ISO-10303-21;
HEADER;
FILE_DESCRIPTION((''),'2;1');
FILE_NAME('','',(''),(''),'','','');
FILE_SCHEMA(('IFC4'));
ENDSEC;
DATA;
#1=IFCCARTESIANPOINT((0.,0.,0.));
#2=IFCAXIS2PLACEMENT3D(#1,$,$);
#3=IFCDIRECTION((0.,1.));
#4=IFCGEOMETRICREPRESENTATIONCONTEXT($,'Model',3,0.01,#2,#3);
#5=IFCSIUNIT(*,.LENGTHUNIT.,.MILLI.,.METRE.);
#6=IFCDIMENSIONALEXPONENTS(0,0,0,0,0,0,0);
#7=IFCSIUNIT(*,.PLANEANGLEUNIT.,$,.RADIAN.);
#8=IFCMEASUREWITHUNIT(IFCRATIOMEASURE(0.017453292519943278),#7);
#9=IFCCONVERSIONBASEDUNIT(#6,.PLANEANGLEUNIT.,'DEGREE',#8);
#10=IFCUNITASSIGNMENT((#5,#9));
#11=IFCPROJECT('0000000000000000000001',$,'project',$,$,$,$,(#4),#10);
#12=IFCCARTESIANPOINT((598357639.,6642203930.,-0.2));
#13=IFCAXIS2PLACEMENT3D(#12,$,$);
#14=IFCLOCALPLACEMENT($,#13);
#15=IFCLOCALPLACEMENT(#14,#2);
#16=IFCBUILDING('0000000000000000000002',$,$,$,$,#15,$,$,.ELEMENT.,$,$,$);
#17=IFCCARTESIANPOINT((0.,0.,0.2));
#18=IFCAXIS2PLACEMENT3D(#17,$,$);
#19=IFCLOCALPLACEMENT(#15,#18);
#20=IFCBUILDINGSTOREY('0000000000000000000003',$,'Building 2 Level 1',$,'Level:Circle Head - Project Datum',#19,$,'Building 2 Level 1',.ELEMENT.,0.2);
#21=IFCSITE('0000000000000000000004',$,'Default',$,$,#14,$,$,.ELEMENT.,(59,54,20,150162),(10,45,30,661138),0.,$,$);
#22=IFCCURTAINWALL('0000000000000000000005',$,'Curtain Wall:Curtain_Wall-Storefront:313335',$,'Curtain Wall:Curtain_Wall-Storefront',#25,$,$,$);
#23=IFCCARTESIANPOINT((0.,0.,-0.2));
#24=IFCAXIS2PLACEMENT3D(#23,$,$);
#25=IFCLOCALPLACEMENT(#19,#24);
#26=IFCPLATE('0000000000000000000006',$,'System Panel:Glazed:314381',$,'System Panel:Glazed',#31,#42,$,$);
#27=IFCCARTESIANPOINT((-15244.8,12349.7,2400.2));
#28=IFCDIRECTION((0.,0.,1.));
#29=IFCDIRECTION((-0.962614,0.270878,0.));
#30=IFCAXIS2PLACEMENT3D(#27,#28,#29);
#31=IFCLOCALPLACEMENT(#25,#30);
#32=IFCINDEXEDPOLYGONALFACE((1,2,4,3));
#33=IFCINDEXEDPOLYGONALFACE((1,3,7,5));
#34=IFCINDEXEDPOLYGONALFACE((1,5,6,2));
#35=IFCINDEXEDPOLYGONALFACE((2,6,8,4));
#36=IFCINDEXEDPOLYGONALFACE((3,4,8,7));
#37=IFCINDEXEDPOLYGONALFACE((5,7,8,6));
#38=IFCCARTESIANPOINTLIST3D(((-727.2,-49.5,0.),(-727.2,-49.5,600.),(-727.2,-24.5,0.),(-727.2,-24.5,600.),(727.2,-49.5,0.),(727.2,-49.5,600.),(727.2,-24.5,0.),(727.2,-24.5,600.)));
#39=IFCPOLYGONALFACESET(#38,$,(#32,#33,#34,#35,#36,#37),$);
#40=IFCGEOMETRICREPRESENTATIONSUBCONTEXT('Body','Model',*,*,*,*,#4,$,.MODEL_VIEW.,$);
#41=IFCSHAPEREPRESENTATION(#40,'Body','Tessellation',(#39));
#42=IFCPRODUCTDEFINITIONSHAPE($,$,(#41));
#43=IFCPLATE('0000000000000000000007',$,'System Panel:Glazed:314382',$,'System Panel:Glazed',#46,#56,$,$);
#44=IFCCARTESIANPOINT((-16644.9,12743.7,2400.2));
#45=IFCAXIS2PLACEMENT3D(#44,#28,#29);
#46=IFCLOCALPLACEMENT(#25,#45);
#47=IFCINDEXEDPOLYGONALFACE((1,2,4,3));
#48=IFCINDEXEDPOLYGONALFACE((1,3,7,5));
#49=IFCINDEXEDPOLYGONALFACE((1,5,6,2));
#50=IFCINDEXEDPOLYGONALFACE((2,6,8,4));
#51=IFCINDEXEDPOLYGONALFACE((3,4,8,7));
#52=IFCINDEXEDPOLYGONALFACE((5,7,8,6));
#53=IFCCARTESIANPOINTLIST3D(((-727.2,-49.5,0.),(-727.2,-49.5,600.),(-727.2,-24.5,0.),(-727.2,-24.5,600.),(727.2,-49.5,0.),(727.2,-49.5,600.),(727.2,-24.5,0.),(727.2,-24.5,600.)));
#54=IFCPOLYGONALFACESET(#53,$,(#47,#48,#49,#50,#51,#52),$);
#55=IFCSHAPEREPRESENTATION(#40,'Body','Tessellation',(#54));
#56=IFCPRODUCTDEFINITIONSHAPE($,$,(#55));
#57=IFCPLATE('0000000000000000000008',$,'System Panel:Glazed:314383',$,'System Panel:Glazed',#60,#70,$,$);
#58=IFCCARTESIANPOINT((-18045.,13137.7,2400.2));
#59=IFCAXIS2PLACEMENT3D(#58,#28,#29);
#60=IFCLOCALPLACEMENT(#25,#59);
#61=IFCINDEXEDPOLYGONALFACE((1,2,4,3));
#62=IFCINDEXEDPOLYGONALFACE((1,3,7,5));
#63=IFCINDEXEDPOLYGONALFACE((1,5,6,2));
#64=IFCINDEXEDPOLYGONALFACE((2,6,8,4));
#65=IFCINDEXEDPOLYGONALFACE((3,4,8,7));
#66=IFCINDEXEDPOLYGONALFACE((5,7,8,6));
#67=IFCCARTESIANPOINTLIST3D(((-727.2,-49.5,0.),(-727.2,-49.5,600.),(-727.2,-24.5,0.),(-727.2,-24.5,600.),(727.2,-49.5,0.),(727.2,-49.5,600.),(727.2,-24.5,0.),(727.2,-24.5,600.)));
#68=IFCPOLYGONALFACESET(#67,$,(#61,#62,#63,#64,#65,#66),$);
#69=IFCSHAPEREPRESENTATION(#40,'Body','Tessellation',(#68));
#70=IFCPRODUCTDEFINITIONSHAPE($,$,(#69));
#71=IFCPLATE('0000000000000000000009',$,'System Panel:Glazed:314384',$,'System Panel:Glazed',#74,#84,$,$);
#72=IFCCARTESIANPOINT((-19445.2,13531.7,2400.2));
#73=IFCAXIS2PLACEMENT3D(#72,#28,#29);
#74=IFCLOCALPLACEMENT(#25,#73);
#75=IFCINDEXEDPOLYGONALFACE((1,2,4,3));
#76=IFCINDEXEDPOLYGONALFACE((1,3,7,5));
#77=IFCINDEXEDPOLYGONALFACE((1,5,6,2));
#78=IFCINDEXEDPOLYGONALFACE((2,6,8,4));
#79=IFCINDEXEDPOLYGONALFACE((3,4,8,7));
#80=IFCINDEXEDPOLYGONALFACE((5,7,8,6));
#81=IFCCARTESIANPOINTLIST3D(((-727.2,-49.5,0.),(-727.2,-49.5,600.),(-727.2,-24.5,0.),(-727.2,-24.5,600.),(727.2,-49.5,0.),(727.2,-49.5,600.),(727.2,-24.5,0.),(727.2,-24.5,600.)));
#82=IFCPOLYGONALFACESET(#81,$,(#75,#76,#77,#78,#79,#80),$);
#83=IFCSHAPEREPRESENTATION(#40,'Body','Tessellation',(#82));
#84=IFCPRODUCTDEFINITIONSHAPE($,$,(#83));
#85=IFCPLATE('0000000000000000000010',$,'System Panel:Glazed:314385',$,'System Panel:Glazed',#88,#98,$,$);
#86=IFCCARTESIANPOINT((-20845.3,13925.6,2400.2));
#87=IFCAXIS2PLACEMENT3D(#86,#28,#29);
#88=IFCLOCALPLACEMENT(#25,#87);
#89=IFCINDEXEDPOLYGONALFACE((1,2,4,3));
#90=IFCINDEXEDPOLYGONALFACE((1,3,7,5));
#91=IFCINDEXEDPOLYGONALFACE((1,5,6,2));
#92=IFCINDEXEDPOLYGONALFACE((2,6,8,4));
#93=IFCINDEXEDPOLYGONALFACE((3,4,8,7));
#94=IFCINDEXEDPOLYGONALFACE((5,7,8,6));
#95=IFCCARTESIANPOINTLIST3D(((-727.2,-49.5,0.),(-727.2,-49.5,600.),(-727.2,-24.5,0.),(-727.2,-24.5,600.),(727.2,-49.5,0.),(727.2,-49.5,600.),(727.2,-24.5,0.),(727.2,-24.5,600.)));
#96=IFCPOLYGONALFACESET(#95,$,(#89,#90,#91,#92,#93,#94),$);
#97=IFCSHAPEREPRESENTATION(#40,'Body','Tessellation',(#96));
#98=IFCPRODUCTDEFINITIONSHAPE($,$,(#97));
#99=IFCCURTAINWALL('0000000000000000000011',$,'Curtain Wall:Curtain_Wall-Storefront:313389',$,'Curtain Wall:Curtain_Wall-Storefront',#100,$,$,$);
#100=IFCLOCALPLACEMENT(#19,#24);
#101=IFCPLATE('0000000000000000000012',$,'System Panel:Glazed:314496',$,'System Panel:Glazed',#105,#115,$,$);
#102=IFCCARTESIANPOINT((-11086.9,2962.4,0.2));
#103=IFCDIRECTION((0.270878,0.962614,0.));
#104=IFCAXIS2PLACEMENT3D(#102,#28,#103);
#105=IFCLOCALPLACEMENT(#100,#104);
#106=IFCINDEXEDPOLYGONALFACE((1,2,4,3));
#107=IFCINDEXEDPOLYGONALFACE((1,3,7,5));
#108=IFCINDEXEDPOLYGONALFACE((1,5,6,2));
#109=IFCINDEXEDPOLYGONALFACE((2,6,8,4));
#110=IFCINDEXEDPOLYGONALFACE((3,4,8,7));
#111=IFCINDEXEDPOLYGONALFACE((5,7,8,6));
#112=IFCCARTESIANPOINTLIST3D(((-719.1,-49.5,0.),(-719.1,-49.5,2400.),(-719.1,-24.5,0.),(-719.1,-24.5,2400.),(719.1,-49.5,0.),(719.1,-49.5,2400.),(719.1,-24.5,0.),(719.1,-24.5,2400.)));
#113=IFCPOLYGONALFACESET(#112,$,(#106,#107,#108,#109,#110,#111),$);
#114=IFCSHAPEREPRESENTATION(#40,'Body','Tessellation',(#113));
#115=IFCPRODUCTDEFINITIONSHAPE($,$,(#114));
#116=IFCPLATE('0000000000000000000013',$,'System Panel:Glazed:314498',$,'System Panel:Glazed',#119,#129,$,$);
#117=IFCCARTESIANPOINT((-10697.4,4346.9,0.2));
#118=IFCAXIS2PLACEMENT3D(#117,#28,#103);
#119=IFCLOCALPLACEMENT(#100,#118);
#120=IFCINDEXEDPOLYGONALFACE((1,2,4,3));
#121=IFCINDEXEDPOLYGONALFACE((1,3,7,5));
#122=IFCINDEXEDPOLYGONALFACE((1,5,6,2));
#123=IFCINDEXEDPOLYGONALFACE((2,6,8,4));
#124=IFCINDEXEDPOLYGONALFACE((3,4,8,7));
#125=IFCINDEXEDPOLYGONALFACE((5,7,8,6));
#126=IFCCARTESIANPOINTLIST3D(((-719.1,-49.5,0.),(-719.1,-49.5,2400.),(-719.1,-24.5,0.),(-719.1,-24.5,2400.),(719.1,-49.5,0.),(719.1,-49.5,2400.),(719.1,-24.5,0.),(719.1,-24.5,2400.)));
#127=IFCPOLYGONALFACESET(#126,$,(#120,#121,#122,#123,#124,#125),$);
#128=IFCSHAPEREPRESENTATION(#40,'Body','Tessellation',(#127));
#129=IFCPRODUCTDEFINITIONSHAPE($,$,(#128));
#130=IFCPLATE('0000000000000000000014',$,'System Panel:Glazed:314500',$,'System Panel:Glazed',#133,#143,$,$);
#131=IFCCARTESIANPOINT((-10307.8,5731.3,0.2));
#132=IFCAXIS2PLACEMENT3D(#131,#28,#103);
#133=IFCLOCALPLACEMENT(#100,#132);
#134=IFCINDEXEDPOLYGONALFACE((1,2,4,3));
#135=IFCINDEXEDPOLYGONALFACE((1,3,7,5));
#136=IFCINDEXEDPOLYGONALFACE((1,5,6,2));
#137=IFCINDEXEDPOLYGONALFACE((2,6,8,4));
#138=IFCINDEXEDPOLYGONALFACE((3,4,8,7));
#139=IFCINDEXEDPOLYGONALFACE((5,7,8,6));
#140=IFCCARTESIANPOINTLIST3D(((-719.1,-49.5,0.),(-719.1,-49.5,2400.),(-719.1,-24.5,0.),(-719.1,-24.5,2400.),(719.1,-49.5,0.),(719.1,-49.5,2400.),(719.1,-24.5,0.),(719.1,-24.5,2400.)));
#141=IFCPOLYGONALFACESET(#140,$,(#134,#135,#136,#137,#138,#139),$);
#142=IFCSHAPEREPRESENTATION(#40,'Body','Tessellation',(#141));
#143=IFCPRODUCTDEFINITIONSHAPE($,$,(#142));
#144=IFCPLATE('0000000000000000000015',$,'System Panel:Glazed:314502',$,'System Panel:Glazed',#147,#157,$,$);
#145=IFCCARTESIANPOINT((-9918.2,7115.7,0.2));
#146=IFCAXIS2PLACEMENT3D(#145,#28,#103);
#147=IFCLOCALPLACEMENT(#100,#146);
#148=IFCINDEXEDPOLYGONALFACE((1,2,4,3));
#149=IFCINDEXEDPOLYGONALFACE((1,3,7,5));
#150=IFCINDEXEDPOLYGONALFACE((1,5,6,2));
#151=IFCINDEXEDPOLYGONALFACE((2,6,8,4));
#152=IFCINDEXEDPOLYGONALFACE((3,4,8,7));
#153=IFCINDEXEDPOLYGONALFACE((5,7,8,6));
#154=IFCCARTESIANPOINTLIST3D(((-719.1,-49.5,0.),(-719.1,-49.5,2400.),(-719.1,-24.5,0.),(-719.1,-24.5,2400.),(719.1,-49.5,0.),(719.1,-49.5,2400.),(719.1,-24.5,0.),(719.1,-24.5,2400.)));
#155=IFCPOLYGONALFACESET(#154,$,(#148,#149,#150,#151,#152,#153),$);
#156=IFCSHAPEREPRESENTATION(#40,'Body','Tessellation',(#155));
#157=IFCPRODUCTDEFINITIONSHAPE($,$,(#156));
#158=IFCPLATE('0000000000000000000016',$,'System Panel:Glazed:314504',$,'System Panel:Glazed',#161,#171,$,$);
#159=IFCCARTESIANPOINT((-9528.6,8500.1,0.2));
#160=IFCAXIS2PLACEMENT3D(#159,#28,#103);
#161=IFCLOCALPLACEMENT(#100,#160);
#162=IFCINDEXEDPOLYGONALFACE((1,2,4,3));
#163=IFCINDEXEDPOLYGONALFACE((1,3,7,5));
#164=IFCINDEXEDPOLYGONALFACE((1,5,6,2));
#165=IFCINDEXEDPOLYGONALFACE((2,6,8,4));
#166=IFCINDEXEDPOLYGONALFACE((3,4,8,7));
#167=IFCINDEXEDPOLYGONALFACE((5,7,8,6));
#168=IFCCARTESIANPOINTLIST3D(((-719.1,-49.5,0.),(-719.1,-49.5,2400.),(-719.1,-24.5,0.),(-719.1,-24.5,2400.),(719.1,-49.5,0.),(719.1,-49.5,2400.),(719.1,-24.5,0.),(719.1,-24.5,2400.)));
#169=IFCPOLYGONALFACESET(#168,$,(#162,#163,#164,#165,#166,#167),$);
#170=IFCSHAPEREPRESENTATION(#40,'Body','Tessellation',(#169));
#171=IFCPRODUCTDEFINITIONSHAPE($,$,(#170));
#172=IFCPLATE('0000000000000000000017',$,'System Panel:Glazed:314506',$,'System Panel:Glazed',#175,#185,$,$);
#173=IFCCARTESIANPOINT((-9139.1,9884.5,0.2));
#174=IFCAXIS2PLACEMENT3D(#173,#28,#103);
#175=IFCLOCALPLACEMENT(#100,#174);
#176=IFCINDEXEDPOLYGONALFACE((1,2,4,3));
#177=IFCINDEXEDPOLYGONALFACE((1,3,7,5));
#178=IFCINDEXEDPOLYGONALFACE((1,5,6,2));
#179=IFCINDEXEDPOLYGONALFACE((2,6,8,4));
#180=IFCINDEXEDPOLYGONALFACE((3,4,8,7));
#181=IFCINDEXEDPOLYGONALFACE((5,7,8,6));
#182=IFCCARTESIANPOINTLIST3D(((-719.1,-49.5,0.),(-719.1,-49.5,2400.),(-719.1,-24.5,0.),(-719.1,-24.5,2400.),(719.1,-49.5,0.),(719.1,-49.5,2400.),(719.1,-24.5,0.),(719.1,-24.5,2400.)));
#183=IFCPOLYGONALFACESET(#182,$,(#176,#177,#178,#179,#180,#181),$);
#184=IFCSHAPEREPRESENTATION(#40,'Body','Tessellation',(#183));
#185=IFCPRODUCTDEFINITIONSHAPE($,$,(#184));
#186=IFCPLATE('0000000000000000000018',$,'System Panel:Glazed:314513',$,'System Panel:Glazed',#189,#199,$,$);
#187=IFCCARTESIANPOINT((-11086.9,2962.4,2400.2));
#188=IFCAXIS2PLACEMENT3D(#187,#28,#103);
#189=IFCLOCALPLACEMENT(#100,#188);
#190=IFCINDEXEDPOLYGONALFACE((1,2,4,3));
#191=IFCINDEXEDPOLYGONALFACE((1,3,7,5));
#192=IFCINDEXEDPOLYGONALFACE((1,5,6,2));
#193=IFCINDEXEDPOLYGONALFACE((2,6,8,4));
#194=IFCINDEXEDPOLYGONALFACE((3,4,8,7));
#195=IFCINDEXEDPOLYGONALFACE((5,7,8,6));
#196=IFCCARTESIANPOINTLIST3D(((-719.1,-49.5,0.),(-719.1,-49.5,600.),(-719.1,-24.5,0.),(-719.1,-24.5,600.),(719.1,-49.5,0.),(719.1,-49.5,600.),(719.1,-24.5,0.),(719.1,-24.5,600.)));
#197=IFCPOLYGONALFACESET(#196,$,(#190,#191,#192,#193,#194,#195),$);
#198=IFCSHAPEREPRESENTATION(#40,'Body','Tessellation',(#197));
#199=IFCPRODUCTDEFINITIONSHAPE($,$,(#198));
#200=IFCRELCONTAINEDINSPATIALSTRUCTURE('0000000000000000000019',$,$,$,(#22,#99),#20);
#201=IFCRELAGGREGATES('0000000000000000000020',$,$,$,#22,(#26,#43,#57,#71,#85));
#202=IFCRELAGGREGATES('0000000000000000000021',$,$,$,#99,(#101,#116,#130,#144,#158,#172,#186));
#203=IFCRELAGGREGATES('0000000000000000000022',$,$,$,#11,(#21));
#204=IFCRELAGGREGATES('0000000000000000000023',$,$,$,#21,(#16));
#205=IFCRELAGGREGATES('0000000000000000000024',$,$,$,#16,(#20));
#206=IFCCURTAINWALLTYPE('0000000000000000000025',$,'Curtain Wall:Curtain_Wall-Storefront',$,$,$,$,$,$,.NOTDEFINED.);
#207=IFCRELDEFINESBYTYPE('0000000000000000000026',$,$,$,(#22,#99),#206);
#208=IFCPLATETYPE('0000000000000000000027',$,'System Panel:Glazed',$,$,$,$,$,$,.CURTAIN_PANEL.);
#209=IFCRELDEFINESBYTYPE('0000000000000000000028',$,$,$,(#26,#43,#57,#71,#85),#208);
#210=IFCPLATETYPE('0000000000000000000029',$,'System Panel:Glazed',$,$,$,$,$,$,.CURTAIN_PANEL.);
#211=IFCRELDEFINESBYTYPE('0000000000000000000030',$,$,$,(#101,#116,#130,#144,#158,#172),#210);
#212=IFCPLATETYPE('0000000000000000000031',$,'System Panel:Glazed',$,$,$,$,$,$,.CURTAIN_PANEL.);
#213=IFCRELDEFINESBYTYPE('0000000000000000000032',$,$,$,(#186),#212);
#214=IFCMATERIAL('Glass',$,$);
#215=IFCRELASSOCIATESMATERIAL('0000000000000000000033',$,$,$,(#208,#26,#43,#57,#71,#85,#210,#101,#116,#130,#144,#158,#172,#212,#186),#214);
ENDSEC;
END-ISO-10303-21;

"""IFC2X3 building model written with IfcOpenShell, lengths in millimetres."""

from ifc_helpers import new_model, entity, si_unit, converted_unit, direction, frame, frame_2d, origin, place, context, subcontext, project, spatial, rectangle, extrude, source, transform, mapped, material, type_object, type_shapes, element, aggregate, save


model = new_model("IFC2X3")

# Units and contexts
model_context = context("Model", 3, precision=0.01, world=origin(), true_north=direction((0.0, 1.0)))
body_context = subcontext(model_context, "Body", "Model", "MODEL_VIEW")
ifc_project = project(units=[si_unit("LENGTHUNIT", "METRE", prefix="MILLI"), converted_unit("PLANEANGLEUNIT", "DEGREE", entity("IfcRatioMeasure", 0.017453292519943278), si_unit("PLANEANGLEUNIT", "RADIAN"), dimensions=[0, 0, 0, 0, 0, 0, 0])], contexts=[model_context])

# Site, building, storey
site_placement = place(None, frame((598357639.0, 6642203930.0, -0.2)))
site = spatial("IfcSite", under=ifc_project, at=site_placement, Name="Default", CompositionType="ELEMENT", RefLatitude=(59, 54, 20, 150162), RefLongitude=(10, 45, 30, 661138), RefElevation=0.0)
building_placement = place(site_placement, origin())
building = spatial("IfcBuilding", under=site, at=building_placement, CompositionType="ELEMENT")
storey_placement = place(building_placement, frame((0.0, 0.0, 0.2)))
storey = spatial("IfcBuildingStorey", under=building, at=storey_placement, Name="Building 2 Level 1", ObjectType="Level:Circle Head - Project Datum", LongName="Building 2 Level 1", CompositionType="ELEMENT", Elevation=0.2)

# Curtain walls, plates
curtain_wall_type = type_object("IfcCurtainWallType", Name="Curtain Wall:Curtain_Wall-Storefront", PredefinedType="NOTDEFINED")
curtain_wall_1_placement = place(storey_placement, frame((0.0, 0.0, -0.2)))
curtain_wall_1 = element("IfcCurtainWall", 1, at=curtain_wall_1_placement, inside=storey, type_object=curtain_wall_type, Name="Curtain Wall:Curtain_Wall-Storefront:313335", ObjectType="Curtain Wall:Curtain_Wall-Storefront")
ifc_material = material(Name="Glass")
plate_type_1 = type_object("IfcPlateType", Name="System Panel:Glazed", PredefinedType="CURTAIN_PANEL", material=ifc_material)
shared_shape_1 = source(origin(), body_context, "Body", "SweptSolid", [
    extrude(rectangle(XDim=25.0, YDim=1454.5, at=frame_2d((0.0, 0.0), x_axis=(1.0, 0.0))), frame((0.0, -37.0, 0.0), z_axis=(0.0, 0.0, 1.0), x_axis=(0.0, 1.0, 0.0)), (0.0, 0.0, 1.0), 600.0),
])
type_shapes(plate_type_1, [shared_shape_1])
plate_1_placement = place(curtain_wall_1_placement, frame((-15244.8, 12349.7, 2400.2), z_axis=(0.0, 0.0, 1.0), x_axis=(-0.962614, 0.270878, 0.0)))
plate_1 = element("IfcPlate", 2, at=plate_1_placement, type_object=plate_type_1, material=ifc_material, Name="System Panel:Glazed:314381", ObjectType="System Panel:Glazed", context=body_context, shape_type="MappedRepresentation", body=[
    mapped(shared_shape_1, transform((0.0, 0.0, 0.0), scale=1.0)),
])
plate_2_placement = place(curtain_wall_1_placement, frame((-16644.9, 12743.7, 2400.2), z_axis=(0.0, 0.0, 1.0), x_axis=(-0.962614, 0.270878, 0.0)))
plate_2 = element("IfcPlate", 3, at=plate_2_placement, type_object=plate_type_1, material=ifc_material, Name="System Panel:Glazed:314382", ObjectType="System Panel:Glazed", context=body_context, shape_type="MappedRepresentation", body=[
    mapped(shared_shape_1, transform((0.0, 0.0, 0.0), scale=1.0)),
])
plate_3_placement = place(curtain_wall_1_placement, frame((-18045.0, 13137.7, 2400.2), z_axis=(0.0, 0.0, 1.0), x_axis=(-0.962614, 0.270878, 0.0)))
plate_3 = element("IfcPlate", 4, at=plate_3_placement, type_object=plate_type_1, material=ifc_material, Name="System Panel:Glazed:314383", ObjectType="System Panel:Glazed", context=body_context, shape_type="MappedRepresentation", body=[
    mapped(shared_shape_1, transform((0.0, 0.0, 0.0), scale=1.0)),
])
plate_4_placement = place(curtain_wall_1_placement, frame((-19445.2, 13531.7, 2400.2), z_axis=(0.0, 0.0, 1.0), x_axis=(-0.962614, 0.270878, 0.0)))
plate_4 = element("IfcPlate", 5, at=plate_4_placement, type_object=plate_type_1, material=ifc_material, Name="System Panel:Glazed:314384", ObjectType="System Panel:Glazed", context=body_context, shape_type="MappedRepresentation", body=[
    mapped(shared_shape_1, transform((0.0, 0.0, 0.0), scale=1.0)),
])
plate_5_placement = place(curtain_wall_1_placement, frame((-20845.3, 13925.6, 2400.2), z_axis=(0.0, 0.0, 1.0), x_axis=(-0.962614, 0.270878, 0.0)))
plate_5 = element("IfcPlate", 6, at=plate_5_placement, type_object=plate_type_1, material=ifc_material, Name="System Panel:Glazed:314385", ObjectType="System Panel:Glazed", context=body_context, shape_type="MappedRepresentation", body=[
    mapped(shared_shape_1, transform((0.0, 0.0, 0.0), scale=1.0)),
])
aggregate(curtain_wall_1, [plate_1, plate_2, plate_3, plate_4, plate_5])
curtain_wall_2_placement = place(storey_placement, frame((0.0, 0.0, -0.2)))
curtain_wall_2 = element("IfcCurtainWall", 7, at=curtain_wall_2_placement, inside=storey, type_object=curtain_wall_type, Name="Curtain Wall:Curtain_Wall-Storefront:313389", ObjectType="Curtain Wall:Curtain_Wall-Storefront")
plate_type_2 = type_object("IfcPlateType", Name="System Panel:Glazed", PredefinedType="CURTAIN_PANEL", material=ifc_material)
shared_shape_2 = source(origin(), body_context, "Body", "SweptSolid", [
    extrude(rectangle(XDim=25.0, YDim=1438.2, at=frame_2d((0.0, 0.0), x_axis=(1.0, 0.0))), frame((0.0, -37.0, 0.0), z_axis=(0.0, 0.0, 1.0), x_axis=(0.0, 1.0, 0.0)), (0.0, 0.0, 1.0), 2400.0),
])
type_shapes(plate_type_2, [shared_shape_2])
plate_6_placement = place(curtain_wall_2_placement, frame((-11086.9, 2962.4, 0.2), z_axis=(0.0, 0.0, 1.0), x_axis=(0.270878, 0.962614, 0.0)))
plate_6 = element("IfcPlate", 8, at=plate_6_placement, type_object=plate_type_2, material=ifc_material, Name="System Panel:Glazed:314496", ObjectType="System Panel:Glazed", context=body_context, shape_type="MappedRepresentation", body=[
    mapped(shared_shape_2, transform((0.0, 0.0, 0.0), scale=1.0)),
])
plate_7_placement = place(curtain_wall_2_placement, frame((-10697.4, 4346.9, 0.2), z_axis=(0.0, 0.0, 1.0), x_axis=(0.270878, 0.962614, 0.0)))
plate_7 = element("IfcPlate", 9, at=plate_7_placement, type_object=plate_type_2, material=ifc_material, Name="System Panel:Glazed:314498", ObjectType="System Panel:Glazed", context=body_context, shape_type="MappedRepresentation", body=[
    mapped(shared_shape_2, transform((0.0, 0.0, 0.0), scale=1.0)),
])
plate_8_placement = place(curtain_wall_2_placement, frame((-10307.8, 5731.3, 0.2), z_axis=(0.0, 0.0, 1.0), x_axis=(0.270878, 0.962614, 0.0)))
plate_8 = element("IfcPlate", 10, at=plate_8_placement, type_object=plate_type_2, material=ifc_material, Name="System Panel:Glazed:314500", ObjectType="System Panel:Glazed", context=body_context, shape_type="MappedRepresentation", body=[
    mapped(shared_shape_2, transform((0.0, 0.0, 0.0), scale=1.0)),
])
plate_9_placement = place(curtain_wall_2_placement, frame((-9918.2, 7115.7, 0.2), z_axis=(0.0, 0.0, 1.0), x_axis=(0.270878, 0.962614, 0.0)))
plate_9 = element("IfcPlate", 11, at=plate_9_placement, type_object=plate_type_2, material=ifc_material, Name="System Panel:Glazed:314502", ObjectType="System Panel:Glazed", context=body_context, shape_type="MappedRepresentation", body=[
    mapped(shared_shape_2, transform((0.0, 0.0, 0.0), scale=1.0)),
])
plate_10_placement = place(curtain_wall_2_placement, frame((-9528.6, 8500.1, 0.2), z_axis=(0.0, 0.0, 1.0), x_axis=(0.270878, 0.962614, 0.0)))
plate_10 = element("IfcPlate", 12, at=plate_10_placement, type_object=plate_type_2, material=ifc_material, Name="System Panel:Glazed:314504", ObjectType="System Panel:Glazed", context=body_context, shape_type="MappedRepresentation", body=[
    mapped(shared_shape_2, transform((0.0, 0.0, 0.0), scale=1.0)),
])
plate_11_placement = place(curtain_wall_2_placement, frame((-9139.1, 9884.5, 0.2), z_axis=(0.0, 0.0, 1.0), x_axis=(0.270878, 0.962614, 0.0)))
plate_11 = element("IfcPlate", 13, at=plate_11_placement, type_object=plate_type_2, material=ifc_material, Name="System Panel:Glazed:314506", ObjectType="System Panel:Glazed", context=body_context, shape_type="MappedRepresentation", body=[
    mapped(shared_shape_2, transform((0.0, 0.0, 0.0), scale=1.0)),
])
plate_type_3 = type_object("IfcPlateType", Name="System Panel:Glazed", PredefinedType="CURTAIN_PANEL", material=ifc_material)
shared_shape_3 = source(origin(), body_context, "Body", "SweptSolid", [
    extrude(rectangle(XDim=25.0, YDim=1438.2, at=frame_2d((0.0, 0.0), x_axis=(1.0, 0.0))), frame((0.0, -37.0, 0.0), z_axis=(0.0, 0.0, 1.0), x_axis=(0.0, 1.0, 0.0)), (0.0, 0.0, 1.0), 600.0),
])
type_shapes(plate_type_3, [shared_shape_3])
plate_12_placement = place(curtain_wall_2_placement, frame((-11086.9, 2962.4, 2400.2), z_axis=(0.0, 0.0, 1.0), x_axis=(0.270878, 0.962614, 0.0)))
plate_12 = element("IfcPlate", 14, at=plate_12_placement, type_object=plate_type_3, material=ifc_material, Name="System Panel:Glazed:314513", ObjectType="System Panel:Glazed", context=body_context, shape_type="MappedRepresentation", body=[
    mapped(shared_shape_3, transform((0.0, 0.0, 0.0), scale=1.0)),
])
aggregate(curtain_wall_2, [plate_6, plate_7, plate_8, plate_9, plate_10, plate_11, plate_12])

save(model, "model.ifc")
